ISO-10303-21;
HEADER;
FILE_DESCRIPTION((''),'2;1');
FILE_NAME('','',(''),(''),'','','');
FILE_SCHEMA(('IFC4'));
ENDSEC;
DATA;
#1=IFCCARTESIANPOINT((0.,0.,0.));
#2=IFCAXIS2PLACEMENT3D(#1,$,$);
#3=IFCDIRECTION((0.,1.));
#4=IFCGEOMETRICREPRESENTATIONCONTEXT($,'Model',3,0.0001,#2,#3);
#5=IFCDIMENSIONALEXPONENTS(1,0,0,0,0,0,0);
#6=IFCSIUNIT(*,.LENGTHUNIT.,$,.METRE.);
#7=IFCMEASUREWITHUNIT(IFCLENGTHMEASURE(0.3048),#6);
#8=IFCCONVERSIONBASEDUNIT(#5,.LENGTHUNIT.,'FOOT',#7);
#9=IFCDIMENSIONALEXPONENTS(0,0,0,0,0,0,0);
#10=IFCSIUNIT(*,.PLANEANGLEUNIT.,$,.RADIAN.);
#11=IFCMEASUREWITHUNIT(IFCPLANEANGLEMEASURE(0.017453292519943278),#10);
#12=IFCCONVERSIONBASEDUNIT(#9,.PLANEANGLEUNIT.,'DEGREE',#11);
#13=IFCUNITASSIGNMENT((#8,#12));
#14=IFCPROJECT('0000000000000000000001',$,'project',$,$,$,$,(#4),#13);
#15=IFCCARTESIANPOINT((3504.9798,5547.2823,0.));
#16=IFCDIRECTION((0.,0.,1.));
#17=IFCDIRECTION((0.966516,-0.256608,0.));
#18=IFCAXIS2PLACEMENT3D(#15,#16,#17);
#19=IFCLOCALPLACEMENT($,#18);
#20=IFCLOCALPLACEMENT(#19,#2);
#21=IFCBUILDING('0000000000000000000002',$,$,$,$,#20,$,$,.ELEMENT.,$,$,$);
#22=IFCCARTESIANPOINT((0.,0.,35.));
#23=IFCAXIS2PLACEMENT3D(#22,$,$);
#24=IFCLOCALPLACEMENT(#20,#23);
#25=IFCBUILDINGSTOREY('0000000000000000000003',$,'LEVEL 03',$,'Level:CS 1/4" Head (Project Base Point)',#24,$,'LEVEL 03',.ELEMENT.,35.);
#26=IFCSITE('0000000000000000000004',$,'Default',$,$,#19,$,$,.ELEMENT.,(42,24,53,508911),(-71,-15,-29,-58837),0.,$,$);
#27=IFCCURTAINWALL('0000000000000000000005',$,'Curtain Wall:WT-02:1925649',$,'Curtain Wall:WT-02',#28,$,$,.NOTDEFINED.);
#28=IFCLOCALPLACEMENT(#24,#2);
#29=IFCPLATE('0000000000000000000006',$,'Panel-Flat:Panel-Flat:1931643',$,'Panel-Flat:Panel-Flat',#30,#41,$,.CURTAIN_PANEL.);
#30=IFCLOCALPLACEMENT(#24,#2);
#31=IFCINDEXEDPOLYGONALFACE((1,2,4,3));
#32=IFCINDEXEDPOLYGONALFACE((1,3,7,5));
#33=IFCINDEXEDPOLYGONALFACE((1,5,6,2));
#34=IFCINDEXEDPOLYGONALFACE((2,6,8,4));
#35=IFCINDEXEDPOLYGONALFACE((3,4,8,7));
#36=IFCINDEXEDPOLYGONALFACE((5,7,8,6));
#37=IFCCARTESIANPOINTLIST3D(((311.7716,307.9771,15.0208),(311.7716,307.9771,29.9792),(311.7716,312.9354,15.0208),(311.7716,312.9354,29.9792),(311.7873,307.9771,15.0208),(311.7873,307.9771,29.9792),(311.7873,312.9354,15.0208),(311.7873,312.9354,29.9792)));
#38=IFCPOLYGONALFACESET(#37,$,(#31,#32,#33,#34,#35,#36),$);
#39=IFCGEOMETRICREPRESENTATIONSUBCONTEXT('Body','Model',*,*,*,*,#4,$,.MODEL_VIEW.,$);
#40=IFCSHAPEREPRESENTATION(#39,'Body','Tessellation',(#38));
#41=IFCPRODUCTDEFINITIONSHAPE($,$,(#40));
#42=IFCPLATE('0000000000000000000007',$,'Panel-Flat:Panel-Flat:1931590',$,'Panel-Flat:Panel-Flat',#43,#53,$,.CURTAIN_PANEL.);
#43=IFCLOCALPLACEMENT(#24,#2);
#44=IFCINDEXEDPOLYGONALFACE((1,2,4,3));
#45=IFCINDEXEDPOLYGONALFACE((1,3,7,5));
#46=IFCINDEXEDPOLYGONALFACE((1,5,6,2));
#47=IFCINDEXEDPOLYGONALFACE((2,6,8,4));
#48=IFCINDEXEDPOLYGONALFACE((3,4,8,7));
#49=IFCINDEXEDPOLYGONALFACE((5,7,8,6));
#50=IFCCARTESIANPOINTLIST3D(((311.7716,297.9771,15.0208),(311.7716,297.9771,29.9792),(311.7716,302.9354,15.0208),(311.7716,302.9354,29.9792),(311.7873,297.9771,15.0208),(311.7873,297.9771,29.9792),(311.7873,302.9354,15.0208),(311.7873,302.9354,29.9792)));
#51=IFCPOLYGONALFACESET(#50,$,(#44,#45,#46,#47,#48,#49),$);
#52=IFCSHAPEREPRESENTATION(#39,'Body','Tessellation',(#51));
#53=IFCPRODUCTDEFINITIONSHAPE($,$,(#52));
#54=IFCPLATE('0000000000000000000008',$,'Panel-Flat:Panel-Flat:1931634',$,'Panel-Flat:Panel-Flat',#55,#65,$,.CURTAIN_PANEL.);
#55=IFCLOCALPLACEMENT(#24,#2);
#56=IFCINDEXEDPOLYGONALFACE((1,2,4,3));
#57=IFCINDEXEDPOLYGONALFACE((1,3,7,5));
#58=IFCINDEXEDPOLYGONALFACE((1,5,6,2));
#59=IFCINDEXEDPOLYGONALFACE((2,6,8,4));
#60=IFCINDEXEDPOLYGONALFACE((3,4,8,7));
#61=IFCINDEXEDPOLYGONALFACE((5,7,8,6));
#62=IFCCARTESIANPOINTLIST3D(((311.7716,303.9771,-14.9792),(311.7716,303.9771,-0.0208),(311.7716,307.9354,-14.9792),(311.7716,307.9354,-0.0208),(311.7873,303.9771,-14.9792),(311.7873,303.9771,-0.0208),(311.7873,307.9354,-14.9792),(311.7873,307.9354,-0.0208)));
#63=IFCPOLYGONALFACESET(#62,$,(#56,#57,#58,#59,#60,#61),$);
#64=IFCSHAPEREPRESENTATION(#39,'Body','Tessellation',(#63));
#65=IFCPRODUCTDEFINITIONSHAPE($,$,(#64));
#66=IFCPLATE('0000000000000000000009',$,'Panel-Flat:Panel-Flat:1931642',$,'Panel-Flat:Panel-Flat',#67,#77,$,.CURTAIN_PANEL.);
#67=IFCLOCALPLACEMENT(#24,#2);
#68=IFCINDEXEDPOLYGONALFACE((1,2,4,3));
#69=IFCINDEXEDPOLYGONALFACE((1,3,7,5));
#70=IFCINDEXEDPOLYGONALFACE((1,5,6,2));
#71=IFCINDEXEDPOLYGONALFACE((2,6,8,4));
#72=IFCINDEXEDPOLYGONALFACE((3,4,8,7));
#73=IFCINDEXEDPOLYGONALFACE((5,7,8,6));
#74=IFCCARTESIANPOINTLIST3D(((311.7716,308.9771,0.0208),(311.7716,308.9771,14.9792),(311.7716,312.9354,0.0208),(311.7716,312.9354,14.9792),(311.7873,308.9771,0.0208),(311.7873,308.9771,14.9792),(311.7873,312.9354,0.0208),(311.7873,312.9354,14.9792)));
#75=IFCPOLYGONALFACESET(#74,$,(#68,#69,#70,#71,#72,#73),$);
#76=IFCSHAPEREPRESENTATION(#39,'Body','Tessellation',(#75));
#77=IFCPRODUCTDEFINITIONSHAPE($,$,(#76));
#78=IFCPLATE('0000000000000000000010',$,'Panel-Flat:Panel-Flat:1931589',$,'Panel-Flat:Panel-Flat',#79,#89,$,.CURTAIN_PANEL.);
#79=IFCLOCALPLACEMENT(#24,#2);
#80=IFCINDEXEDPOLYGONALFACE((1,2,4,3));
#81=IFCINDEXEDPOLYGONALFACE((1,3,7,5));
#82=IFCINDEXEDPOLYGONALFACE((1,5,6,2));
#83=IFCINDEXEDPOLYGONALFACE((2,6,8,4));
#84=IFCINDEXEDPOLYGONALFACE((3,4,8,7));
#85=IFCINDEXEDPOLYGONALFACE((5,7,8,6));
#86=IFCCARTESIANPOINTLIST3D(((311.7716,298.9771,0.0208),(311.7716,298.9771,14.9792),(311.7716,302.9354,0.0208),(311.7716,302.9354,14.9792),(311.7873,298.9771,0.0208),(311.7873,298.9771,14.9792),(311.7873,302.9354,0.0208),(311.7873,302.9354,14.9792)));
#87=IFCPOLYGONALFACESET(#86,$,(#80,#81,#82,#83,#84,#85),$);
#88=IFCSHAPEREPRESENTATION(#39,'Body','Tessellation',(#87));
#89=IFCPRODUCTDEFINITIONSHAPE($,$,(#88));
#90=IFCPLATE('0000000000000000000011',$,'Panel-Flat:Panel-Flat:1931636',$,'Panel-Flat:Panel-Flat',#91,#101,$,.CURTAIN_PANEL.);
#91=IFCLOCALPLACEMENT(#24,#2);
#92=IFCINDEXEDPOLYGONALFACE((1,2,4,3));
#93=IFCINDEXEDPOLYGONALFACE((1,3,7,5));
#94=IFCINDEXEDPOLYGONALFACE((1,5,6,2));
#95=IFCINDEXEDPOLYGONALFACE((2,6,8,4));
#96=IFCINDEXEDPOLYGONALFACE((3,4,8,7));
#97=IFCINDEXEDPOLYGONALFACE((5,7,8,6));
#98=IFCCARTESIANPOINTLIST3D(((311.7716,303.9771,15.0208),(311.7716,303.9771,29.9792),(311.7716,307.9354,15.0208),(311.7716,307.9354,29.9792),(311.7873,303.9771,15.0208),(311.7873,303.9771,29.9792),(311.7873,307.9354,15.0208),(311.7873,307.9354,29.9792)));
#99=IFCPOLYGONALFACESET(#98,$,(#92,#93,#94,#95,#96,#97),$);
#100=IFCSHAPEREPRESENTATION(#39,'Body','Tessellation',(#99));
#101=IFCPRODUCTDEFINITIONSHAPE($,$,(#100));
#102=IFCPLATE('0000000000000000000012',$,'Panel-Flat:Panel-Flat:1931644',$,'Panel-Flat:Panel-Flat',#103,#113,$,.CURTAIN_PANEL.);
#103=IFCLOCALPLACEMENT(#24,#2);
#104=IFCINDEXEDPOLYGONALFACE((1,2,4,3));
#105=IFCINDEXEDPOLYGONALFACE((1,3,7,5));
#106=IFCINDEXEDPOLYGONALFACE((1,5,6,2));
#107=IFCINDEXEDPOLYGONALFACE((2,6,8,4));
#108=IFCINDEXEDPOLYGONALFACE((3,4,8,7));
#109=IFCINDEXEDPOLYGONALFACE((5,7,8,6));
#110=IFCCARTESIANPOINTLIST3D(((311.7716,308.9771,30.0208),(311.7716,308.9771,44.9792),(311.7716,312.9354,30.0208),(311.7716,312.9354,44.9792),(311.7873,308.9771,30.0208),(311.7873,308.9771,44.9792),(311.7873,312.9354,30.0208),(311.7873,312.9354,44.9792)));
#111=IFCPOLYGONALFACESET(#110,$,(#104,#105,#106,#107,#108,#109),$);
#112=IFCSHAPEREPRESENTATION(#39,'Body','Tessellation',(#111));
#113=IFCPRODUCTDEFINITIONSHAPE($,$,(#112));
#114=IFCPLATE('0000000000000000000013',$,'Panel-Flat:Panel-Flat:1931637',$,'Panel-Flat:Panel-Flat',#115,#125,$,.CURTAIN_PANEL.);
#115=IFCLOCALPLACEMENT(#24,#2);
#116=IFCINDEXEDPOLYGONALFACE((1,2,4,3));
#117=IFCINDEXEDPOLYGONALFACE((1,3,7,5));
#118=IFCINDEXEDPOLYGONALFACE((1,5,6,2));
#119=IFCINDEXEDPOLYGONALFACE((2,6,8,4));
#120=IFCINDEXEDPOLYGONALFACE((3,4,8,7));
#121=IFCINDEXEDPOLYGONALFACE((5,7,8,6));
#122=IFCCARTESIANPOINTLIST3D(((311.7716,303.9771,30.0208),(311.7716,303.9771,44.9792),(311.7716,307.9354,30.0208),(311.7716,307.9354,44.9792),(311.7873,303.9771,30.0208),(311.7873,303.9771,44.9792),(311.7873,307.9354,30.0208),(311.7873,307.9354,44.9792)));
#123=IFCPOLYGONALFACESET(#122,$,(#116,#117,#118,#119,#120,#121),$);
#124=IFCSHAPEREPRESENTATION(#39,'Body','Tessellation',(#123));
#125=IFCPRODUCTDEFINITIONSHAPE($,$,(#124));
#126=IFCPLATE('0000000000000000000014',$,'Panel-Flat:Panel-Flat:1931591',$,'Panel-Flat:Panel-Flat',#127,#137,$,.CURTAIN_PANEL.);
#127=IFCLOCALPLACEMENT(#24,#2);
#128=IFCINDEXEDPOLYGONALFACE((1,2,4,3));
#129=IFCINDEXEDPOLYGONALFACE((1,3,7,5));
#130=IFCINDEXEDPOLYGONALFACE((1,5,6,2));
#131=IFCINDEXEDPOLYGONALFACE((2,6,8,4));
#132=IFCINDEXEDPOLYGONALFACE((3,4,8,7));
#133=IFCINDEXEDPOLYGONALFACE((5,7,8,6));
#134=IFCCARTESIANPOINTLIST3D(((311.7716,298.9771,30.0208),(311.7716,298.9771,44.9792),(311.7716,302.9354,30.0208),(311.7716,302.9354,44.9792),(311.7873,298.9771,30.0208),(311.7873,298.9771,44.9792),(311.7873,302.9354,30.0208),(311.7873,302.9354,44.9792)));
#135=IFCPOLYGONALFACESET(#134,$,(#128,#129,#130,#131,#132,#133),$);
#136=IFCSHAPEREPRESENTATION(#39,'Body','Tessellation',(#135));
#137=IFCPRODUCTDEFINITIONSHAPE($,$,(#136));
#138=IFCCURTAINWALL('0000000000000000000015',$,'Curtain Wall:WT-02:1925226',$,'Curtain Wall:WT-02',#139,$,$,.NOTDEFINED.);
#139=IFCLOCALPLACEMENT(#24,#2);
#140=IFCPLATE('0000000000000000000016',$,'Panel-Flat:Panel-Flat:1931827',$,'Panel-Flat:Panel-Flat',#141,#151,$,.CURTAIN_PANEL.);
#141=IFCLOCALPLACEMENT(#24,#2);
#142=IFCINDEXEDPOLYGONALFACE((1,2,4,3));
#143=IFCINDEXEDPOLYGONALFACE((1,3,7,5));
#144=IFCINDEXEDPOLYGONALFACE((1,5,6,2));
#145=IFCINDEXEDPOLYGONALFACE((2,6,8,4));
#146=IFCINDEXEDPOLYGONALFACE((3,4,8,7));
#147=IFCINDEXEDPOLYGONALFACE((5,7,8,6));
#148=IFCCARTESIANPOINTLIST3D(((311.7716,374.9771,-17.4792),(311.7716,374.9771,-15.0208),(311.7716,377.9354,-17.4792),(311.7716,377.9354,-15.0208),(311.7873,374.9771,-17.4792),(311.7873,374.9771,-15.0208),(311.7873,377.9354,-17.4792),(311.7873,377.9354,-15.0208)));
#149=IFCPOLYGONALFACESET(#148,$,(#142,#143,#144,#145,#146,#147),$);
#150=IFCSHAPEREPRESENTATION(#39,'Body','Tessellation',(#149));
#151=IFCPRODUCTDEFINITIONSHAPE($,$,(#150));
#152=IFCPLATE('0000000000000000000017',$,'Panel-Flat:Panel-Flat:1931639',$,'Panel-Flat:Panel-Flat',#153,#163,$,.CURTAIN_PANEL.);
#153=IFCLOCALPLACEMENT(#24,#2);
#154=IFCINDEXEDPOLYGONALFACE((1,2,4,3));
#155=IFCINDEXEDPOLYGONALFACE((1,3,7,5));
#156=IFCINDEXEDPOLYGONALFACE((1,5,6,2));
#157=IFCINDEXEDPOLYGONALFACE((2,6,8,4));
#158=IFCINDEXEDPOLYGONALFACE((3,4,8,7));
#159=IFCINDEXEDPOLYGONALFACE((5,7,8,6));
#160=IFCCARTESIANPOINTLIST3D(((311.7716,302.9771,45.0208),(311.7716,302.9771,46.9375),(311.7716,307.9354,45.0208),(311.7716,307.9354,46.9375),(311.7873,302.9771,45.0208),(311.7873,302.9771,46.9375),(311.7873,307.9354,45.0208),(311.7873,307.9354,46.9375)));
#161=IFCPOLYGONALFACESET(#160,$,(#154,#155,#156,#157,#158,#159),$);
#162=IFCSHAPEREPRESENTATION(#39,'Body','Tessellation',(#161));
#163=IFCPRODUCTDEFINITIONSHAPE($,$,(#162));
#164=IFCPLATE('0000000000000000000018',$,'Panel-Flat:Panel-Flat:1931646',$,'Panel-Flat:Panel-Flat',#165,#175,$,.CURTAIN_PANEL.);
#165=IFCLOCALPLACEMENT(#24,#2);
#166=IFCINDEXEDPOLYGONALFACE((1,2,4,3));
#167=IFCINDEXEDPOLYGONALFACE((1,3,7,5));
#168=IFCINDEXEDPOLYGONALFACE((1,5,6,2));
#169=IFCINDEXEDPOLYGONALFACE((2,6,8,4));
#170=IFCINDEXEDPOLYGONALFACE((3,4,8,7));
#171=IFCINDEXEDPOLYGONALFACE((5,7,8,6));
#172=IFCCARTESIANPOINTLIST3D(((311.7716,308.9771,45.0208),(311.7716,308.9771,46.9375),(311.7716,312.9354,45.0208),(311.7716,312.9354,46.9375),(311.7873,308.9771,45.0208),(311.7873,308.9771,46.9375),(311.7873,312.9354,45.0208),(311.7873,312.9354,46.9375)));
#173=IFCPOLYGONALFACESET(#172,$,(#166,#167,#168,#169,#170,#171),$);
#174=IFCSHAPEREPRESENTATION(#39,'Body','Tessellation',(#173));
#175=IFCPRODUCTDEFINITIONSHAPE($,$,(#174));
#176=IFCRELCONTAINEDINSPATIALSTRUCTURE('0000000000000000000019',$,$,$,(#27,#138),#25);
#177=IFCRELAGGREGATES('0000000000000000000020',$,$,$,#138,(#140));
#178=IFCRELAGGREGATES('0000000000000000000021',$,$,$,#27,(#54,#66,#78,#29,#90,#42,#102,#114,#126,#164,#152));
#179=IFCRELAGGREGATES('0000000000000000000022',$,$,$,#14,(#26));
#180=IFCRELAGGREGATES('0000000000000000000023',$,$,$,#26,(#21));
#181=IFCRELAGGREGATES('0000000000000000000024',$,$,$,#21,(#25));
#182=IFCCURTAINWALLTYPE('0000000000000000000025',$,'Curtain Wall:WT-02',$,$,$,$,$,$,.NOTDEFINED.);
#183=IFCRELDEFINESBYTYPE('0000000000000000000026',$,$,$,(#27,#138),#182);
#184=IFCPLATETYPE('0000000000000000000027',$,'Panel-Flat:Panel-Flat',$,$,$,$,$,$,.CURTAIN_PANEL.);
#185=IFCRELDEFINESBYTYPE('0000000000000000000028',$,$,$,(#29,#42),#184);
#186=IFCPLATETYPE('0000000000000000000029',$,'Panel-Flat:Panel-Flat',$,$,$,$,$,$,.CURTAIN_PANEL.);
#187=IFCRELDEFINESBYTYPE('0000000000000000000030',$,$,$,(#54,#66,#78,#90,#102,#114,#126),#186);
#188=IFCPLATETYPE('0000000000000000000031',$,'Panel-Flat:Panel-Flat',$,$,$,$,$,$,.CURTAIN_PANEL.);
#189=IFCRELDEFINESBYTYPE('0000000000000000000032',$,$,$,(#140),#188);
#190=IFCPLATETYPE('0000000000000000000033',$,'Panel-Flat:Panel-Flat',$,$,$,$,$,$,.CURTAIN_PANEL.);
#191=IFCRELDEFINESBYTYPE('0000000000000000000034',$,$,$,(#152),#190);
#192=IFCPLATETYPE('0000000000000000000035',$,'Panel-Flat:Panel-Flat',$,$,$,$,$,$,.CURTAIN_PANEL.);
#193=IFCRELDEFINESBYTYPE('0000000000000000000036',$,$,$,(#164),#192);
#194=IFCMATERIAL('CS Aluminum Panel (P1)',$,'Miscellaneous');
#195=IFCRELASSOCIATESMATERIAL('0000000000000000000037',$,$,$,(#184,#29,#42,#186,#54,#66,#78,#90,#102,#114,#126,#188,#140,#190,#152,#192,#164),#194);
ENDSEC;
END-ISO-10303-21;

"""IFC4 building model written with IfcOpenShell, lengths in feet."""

from ifc_helpers import new_model, entity, si_unit, converted_unit, direction, frame, origin, place, context, subcontext, project, spatial, indexed_curve, outline, extrude, source, transform, mapped, material, type_object, type_shapes, element, aggregate, save


model = new_model("IFC4")

# Units and contexts
model_context = context("Model", 3, precision=0.0001, world=origin(), true_north=direction((0.0, 1.0)))
body_context = subcontext(model_context, "Body", "Model", "MODEL_VIEW")
ifc_project = project(units=[converted_unit("LENGTHUNIT", "FOOT", entity("IfcLengthMeasure", 0.3048), si_unit("LENGTHUNIT", "METRE"), dimensions=[1, 0, 0, 0, 0, 0, 0]), converted_unit("PLANEANGLEUNIT", "DEGREE", entity("IfcPlaneAngleMeasure", 0.017453292519943278), si_unit("PLANEANGLEUNIT", "RADIAN"), dimensions=[0, 0, 0, 0, 0, 0, 0])], contexts=[model_context])

# Site, building, storey
site_placement = place(None, frame((3504.9798, 5547.2823, 0.0), z_axis=(0.0, 0.0, 1.0), x_axis=(0.966516, -0.256608, 0.0)))
site = spatial("IfcSite", under=ifc_project, at=site_placement, Name="Default", CompositionType="ELEMENT", RefLatitude=(42, 24, 53, 508911), RefLongitude=(-71, -15, -29, -58837), RefElevation=0.0)
building_placement = place(site_placement, origin())
building = spatial("IfcBuilding", under=site, at=building_placement, CompositionType="ELEMENT")
storey_placement = place(building_placement, frame((0.0, 0.0, 35.0)))
storey = spatial("IfcBuildingStorey", under=building, at=storey_placement, Name="LEVEL 03", ObjectType="Level:CS 1/4\" Head (Project Base Point)", LongName="LEVEL 03", CompositionType="ELEMENT", Elevation=35.0)

# Curtain walls, plates
curtain_wall_type = type_object("IfcCurtainWallType", Name="Curtain Wall:WT-02", PredefinedType="NOTDEFINED")
curtain_wall_1_placement = place(storey_placement, frame((0.0, 0.0, -35.0)))
curtain_wall_1 = element("IfcCurtainWall", 1, at=curtain_wall_1_placement, inside=storey, type_object=curtain_wall_type, Name="Curtain Wall:WT-02:1925649", ObjectType="Curtain Wall:WT-02", PredefinedType="NOTDEFINED")
ifc_material_1 = material(Name="CS Aluminum Panel (P1)", Category="Miscellaneous")
plate_type_1 = type_object("IfcPlateType", Name="Panel-Flat:Panel-Flat", PredefinedType="CURTAIN_PANEL", material=ifc_material_1)
shared_shape_1 = source(origin(), body_context, "Body", "SweptSolid", [
    extrude(outline(indexed_curve([(-0.0078, -2.4792), (0.0078, -2.4792), (0.0078, 2.4792), (-0.0078, 2.4792), (-0.0078, -2.4792)], self_intersect=False)), frame((0.0, -0.0078, 0.0208), z_axis=(0.0, 0.0, 1.0), x_axis=(0.0, -1.0, 0.0)), (0.0, 0.0, 1.0), 14.9583),
])
type_shapes(plate_type_1, [shared_shape_1])
plate_1_placement = place(curtain_wall_1_placement, frame((311.7873, 310.4563, 50.0), z_axis=(0.0, 0.0, 1.0), x_axis=(0.0, -1.0, 0.0)))
plate_1 = element("IfcPlate", 2, at=plate_1_placement, type_object=plate_type_1, material=ifc_material_1, Name="Panel-Flat:Panel-Flat:1931643", ObjectType="Panel-Flat:Panel-Flat", PredefinedType="CURTAIN_PANEL", context=body_context, shape_type="MappedRepresentation", body=[
    mapped(shared_shape_1, transform((0.0, 0.0, 0.0), scale=1.0)),
])
plate_2_placement = place(curtain_wall_1_placement, frame((311.7873, 300.4563, 50.0), z_axis=(0.0, 0.0, 1.0), x_axis=(0.0, -1.0, 0.0)))
plate_2 = element("IfcPlate", 3, at=plate_2_placement, type_object=plate_type_1, material=ifc_material_1, Name="Panel-Flat:Panel-Flat:1931590", ObjectType="Panel-Flat:Panel-Flat", PredefinedType="CURTAIN_PANEL", context=body_context, shape_type="MappedRepresentation", body=[
    mapped(shared_shape_1, transform((0.0, 0.0, 0.0), scale=1.0)),
])
plate_type_2 = type_object("IfcPlateType", Name="Panel-Flat:Panel-Flat", PredefinedType="CURTAIN_PANEL", material=ifc_material_1)
shared_shape_2 = source(origin(), body_context, "Body", "SweptSolid", [
    extrude(outline(indexed_curve([(-0.0078, -1.9792), (0.0078, -1.9792), (0.0078, 1.9792), (-0.0078, 1.9792), (-0.0078, -1.9792)], self_intersect=False)), frame((0.0, -0.0078, 0.0208), z_axis=(0.0, 0.0, 1.0), x_axis=(0.0, -1.0, 0.0)), (0.0, 0.0, 1.0), 14.9583),
])
type_shapes(plate_type_2, [shared_shape_2])
plate_3_placement = place(curtain_wall_1_placement, frame((311.7873, 305.9563, 20.0), z_axis=(0.0, 0.0, 1.0), x_axis=(0.0, -1.0, 0.0)))
plate_3 = element("IfcPlate", 4, at=plate_3_placement, type_object=plate_type_2, material=ifc_material_1, Name="Panel-Flat:Panel-Flat:1931634", ObjectType="Panel-Flat:Panel-Flat", PredefinedType="CURTAIN_PANEL", context=body_context, shape_type="MappedRepresentation", body=[
    mapped(shared_shape_2, transform((0.0, 0.0, 0.0), scale=1.0)),
])
plate_4_placement = place(curtain_wall_1_placement, frame((311.7873, 310.9563, 35.0), z_axis=(0.0, 0.0, 1.0), x_axis=(0.0, -1.0, 0.0)))
plate_4 = element("IfcPlate", 5, at=plate_4_placement, type_object=plate_type_2, material=ifc_material_1, Name="Panel-Flat:Panel-Flat:1931642", ObjectType="Panel-Flat:Panel-Flat", PredefinedType="CURTAIN_PANEL", context=body_context, shape_type="MappedRepresentation", body=[
    mapped(shared_shape_2, transform((0.0, 0.0, 0.0), scale=1.0)),
])
plate_5_placement = place(curtain_wall_1_placement, frame((311.7873, 300.9563, 35.0), z_axis=(0.0, 0.0, 1.0), x_axis=(0.0, -1.0, 0.0)))
plate_5 = element("IfcPlate", 6, at=plate_5_placement, type_object=plate_type_2, material=ifc_material_1, Name="Panel-Flat:Panel-Flat:1931589", ObjectType="Panel-Flat:Panel-Flat", PredefinedType="CURTAIN_PANEL", context=body_context, shape_type="MappedRepresentation", body=[
    mapped(shared_shape_2, transform((0.0, 0.0, 0.0), scale=1.0)),
])
plate_6_placement = place(curtain_wall_1_placement, frame((311.7873, 305.9563, 50.0), z_axis=(0.0, 0.0, 1.0), x_axis=(0.0, -1.0, 0.0)))
plate_6 = element("IfcPlate", 7, at=plate_6_placement, type_object=plate_type_2, material=ifc_material_1, Name="Panel-Flat:Panel-Flat:1931636", ObjectType="Panel-Flat:Panel-Flat", PredefinedType="CURTAIN_PANEL", context=body_context, shape_type="MappedRepresentation", body=[
    mapped(shared_shape_2, transform((0.0, 0.0, 0.0), scale=1.0)),
])
plate_7_placement = place(curtain_wall_1_placement, frame((311.7873, 310.9563, 65.0), z_axis=(0.0, 0.0, 1.0), x_axis=(0.0, -1.0, 0.0)))
plate_7 = element("IfcPlate", 8, at=plate_7_placement, type_object=plate_type_2, material=ifc_material_1, Name="Panel-Flat:Panel-Flat:1931644", ObjectType="Panel-Flat:Panel-Flat", PredefinedType="CURTAIN_PANEL", context=body_context, shape_type="MappedRepresentation", body=[
    mapped(shared_shape_2, transform((0.0, 0.0, 0.0), scale=1.0)),
])
plate_8_placement = place(curtain_wall_1_placement, frame((311.7873, 305.9563, 65.0), z_axis=(0.0, 0.0, 1.0), x_axis=(0.0, -1.0, 0.0)))
plate_8 = element("IfcPlate", 9, at=plate_8_placement, type_object=plate_type_2, material=ifc_material_1, Name="Panel-Flat:Panel-Flat:1931637", ObjectType="Panel-Flat:Panel-Flat", PredefinedType="CURTAIN_PANEL", context=body_context, shape_type="MappedRepresentation", body=[
    mapped(shared_shape_2, transform((0.0, 0.0, 0.0), scale=1.0)),
])
plate_9_placement = place(curtain_wall_1_placement, frame((311.7873, 300.9563, 65.0), z_axis=(0.0, 0.0, 1.0), x_axis=(0.0, -1.0, 0.0)))
plate_9 = element("IfcPlate", 10, at=plate_9_placement, type_object=plate_type_2, material=ifc_material_1, Name="Panel-Flat:Panel-Flat:1931591", ObjectType="Panel-Flat:Panel-Flat", PredefinedType="CURTAIN_PANEL", context=body_context, shape_type="MappedRepresentation", body=[
    mapped(shared_shape_2, transform((0.0, 0.0, 0.0), scale=1.0)),
])
curtain_wall_2_placement = place(storey_placement, frame((0.0, 0.0, -35.0)))
curtain_wall_2 = element("IfcCurtainWall", 11, at=curtain_wall_2_placement, inside=storey, type_object=curtain_wall_type, Name="Curtain Wall:WT-02:1925226", ObjectType="Curtain Wall:WT-02", PredefinedType="NOTDEFINED")
plate_type_3 = type_object("IfcPlateType", Name="Panel-Flat:Panel-Flat", PredefinedType="CURTAIN_PANEL", material=ifc_material_1)
shared_shape_3 = source(origin(), body_context, "Body", "SweptSolid", [
    extrude(outline(indexed_curve([(-0.0078, -1.4792), (0.0078, -1.4792), (0.0078, 1.4792), (-0.0078, 1.4792), (-0.0078, -1.4792)], self_intersect=False)), frame((0.0, -0.0078, 0.0208), z_axis=(0.0, 0.0, 1.0), x_axis=(0.0, -1.0, 0.0)), (0.0, 0.0, 1.0), 2.4583),
])
type_shapes(plate_type_3, [shared_shape_3])
plate_10_placement = place(curtain_wall_2_placement, frame((311.7873, 376.4563, 17.5), z_axis=(0.0, 0.0, 1.0), x_axis=(0.0, -1.0, 0.0)))
plate_10 = element("IfcPlate", 12, at=plate_10_placement, type_object=plate_type_3, material=ifc_material_1, Name="Panel-Flat:Panel-Flat:1931827", ObjectType="Panel-Flat:Panel-Flat", PredefinedType="CURTAIN_PANEL", context=body_context, shape_type="MappedRepresentation", body=[
    mapped(shared_shape_3, transform((0.0, 0.0, 0.0), scale=1.0)),
])
aggregate(curtain_wall_2, [plate_10])

# Plates
plate_type_4 = type_object("IfcPlateType", Name="Panel-Flat:Panel-Flat", PredefinedType="CURTAIN_PANEL", material=ifc_material_1)
shared_shape_4 = source(origin(), body_context, "Body", "SweptSolid", [
    extrude(outline(indexed_curve([(-0.0078, -2.4792), (0.0078, -2.4792), (0.0078, 2.4792), (-0.0078, 2.4792), (-0.0078, -2.4792)], self_intersect=False)), frame((0.0, -0.0078, 0.0208), z_axis=(0.0, 0.0, 1.0), x_axis=(0.0, -1.0, 0.0)), (0.0, 0.0, 1.0), 1.9167),
])
type_shapes(plate_type_4, [shared_shape_4])
plate_11_placement = place(curtain_wall_1_placement, frame((311.7873, 305.4563, 80.0), z_axis=(0.0, 0.0, 1.0), x_axis=(0.0, -1.0, 0.0)))
plate_11 = element("IfcPlate", 13, at=plate_11_placement, type_object=plate_type_4, material=ifc_material_1, Name="Panel-Flat:Panel-Flat:1931639", ObjectType="Panel-Flat:Panel-Flat", PredefinedType="CURTAIN_PANEL", context=body_context, shape_type="MappedRepresentation", body=[
    mapped(shared_shape_4, transform((0.0, 0.0, 0.0), scale=1.0)),
])
plate_type_5 = type_object("IfcPlateType", Name="Panel-Flat:Panel-Flat", PredefinedType="CURTAIN_PANEL", material=ifc_material_1)
shared_shape_5 = source(origin(), body_context, "Body", "SweptSolid", [
    extrude(outline(indexed_curve([(-0.0078, -1.9792), (0.0078, -1.9792), (0.0078, 1.9792), (-0.0078, 1.9792), (-0.0078, -1.9792)], self_intersect=False)), frame((0.0, -0.0078, 0.0208), z_axis=(0.0, 0.0, 1.0), x_axis=(0.0, -1.0, 0.0)), (0.0, 0.0, 1.0), 1.9167),
])
type_shapes(plate_type_5, [shared_shape_5])
plate_12_placement = place(curtain_wall_1_placement, frame((311.7873, 310.9563, 80.0), z_axis=(0.0, 0.0, 1.0), x_axis=(0.0, -1.0, 0.0)))
plate_12 = element("IfcPlate", 14, at=plate_12_placement, type_object=plate_type_5, material=ifc_material_1, Name="Panel-Flat:Panel-Flat:1931646", ObjectType="Panel-Flat:Panel-Flat", PredefinedType="CURTAIN_PANEL", context=body_context, shape_type="MappedRepresentation", body=[
    mapped(shared_shape_5, transform((0.0, 0.0, 0.0), scale=1.0)),
])
aggregate(curtain_wall_1, [plate_3, plate_4, plate_5, plate_1, plate_6, plate_2, plate_7, plate_8, plate_9, plate_12, plate_11])

save(model, "model.ifc")
